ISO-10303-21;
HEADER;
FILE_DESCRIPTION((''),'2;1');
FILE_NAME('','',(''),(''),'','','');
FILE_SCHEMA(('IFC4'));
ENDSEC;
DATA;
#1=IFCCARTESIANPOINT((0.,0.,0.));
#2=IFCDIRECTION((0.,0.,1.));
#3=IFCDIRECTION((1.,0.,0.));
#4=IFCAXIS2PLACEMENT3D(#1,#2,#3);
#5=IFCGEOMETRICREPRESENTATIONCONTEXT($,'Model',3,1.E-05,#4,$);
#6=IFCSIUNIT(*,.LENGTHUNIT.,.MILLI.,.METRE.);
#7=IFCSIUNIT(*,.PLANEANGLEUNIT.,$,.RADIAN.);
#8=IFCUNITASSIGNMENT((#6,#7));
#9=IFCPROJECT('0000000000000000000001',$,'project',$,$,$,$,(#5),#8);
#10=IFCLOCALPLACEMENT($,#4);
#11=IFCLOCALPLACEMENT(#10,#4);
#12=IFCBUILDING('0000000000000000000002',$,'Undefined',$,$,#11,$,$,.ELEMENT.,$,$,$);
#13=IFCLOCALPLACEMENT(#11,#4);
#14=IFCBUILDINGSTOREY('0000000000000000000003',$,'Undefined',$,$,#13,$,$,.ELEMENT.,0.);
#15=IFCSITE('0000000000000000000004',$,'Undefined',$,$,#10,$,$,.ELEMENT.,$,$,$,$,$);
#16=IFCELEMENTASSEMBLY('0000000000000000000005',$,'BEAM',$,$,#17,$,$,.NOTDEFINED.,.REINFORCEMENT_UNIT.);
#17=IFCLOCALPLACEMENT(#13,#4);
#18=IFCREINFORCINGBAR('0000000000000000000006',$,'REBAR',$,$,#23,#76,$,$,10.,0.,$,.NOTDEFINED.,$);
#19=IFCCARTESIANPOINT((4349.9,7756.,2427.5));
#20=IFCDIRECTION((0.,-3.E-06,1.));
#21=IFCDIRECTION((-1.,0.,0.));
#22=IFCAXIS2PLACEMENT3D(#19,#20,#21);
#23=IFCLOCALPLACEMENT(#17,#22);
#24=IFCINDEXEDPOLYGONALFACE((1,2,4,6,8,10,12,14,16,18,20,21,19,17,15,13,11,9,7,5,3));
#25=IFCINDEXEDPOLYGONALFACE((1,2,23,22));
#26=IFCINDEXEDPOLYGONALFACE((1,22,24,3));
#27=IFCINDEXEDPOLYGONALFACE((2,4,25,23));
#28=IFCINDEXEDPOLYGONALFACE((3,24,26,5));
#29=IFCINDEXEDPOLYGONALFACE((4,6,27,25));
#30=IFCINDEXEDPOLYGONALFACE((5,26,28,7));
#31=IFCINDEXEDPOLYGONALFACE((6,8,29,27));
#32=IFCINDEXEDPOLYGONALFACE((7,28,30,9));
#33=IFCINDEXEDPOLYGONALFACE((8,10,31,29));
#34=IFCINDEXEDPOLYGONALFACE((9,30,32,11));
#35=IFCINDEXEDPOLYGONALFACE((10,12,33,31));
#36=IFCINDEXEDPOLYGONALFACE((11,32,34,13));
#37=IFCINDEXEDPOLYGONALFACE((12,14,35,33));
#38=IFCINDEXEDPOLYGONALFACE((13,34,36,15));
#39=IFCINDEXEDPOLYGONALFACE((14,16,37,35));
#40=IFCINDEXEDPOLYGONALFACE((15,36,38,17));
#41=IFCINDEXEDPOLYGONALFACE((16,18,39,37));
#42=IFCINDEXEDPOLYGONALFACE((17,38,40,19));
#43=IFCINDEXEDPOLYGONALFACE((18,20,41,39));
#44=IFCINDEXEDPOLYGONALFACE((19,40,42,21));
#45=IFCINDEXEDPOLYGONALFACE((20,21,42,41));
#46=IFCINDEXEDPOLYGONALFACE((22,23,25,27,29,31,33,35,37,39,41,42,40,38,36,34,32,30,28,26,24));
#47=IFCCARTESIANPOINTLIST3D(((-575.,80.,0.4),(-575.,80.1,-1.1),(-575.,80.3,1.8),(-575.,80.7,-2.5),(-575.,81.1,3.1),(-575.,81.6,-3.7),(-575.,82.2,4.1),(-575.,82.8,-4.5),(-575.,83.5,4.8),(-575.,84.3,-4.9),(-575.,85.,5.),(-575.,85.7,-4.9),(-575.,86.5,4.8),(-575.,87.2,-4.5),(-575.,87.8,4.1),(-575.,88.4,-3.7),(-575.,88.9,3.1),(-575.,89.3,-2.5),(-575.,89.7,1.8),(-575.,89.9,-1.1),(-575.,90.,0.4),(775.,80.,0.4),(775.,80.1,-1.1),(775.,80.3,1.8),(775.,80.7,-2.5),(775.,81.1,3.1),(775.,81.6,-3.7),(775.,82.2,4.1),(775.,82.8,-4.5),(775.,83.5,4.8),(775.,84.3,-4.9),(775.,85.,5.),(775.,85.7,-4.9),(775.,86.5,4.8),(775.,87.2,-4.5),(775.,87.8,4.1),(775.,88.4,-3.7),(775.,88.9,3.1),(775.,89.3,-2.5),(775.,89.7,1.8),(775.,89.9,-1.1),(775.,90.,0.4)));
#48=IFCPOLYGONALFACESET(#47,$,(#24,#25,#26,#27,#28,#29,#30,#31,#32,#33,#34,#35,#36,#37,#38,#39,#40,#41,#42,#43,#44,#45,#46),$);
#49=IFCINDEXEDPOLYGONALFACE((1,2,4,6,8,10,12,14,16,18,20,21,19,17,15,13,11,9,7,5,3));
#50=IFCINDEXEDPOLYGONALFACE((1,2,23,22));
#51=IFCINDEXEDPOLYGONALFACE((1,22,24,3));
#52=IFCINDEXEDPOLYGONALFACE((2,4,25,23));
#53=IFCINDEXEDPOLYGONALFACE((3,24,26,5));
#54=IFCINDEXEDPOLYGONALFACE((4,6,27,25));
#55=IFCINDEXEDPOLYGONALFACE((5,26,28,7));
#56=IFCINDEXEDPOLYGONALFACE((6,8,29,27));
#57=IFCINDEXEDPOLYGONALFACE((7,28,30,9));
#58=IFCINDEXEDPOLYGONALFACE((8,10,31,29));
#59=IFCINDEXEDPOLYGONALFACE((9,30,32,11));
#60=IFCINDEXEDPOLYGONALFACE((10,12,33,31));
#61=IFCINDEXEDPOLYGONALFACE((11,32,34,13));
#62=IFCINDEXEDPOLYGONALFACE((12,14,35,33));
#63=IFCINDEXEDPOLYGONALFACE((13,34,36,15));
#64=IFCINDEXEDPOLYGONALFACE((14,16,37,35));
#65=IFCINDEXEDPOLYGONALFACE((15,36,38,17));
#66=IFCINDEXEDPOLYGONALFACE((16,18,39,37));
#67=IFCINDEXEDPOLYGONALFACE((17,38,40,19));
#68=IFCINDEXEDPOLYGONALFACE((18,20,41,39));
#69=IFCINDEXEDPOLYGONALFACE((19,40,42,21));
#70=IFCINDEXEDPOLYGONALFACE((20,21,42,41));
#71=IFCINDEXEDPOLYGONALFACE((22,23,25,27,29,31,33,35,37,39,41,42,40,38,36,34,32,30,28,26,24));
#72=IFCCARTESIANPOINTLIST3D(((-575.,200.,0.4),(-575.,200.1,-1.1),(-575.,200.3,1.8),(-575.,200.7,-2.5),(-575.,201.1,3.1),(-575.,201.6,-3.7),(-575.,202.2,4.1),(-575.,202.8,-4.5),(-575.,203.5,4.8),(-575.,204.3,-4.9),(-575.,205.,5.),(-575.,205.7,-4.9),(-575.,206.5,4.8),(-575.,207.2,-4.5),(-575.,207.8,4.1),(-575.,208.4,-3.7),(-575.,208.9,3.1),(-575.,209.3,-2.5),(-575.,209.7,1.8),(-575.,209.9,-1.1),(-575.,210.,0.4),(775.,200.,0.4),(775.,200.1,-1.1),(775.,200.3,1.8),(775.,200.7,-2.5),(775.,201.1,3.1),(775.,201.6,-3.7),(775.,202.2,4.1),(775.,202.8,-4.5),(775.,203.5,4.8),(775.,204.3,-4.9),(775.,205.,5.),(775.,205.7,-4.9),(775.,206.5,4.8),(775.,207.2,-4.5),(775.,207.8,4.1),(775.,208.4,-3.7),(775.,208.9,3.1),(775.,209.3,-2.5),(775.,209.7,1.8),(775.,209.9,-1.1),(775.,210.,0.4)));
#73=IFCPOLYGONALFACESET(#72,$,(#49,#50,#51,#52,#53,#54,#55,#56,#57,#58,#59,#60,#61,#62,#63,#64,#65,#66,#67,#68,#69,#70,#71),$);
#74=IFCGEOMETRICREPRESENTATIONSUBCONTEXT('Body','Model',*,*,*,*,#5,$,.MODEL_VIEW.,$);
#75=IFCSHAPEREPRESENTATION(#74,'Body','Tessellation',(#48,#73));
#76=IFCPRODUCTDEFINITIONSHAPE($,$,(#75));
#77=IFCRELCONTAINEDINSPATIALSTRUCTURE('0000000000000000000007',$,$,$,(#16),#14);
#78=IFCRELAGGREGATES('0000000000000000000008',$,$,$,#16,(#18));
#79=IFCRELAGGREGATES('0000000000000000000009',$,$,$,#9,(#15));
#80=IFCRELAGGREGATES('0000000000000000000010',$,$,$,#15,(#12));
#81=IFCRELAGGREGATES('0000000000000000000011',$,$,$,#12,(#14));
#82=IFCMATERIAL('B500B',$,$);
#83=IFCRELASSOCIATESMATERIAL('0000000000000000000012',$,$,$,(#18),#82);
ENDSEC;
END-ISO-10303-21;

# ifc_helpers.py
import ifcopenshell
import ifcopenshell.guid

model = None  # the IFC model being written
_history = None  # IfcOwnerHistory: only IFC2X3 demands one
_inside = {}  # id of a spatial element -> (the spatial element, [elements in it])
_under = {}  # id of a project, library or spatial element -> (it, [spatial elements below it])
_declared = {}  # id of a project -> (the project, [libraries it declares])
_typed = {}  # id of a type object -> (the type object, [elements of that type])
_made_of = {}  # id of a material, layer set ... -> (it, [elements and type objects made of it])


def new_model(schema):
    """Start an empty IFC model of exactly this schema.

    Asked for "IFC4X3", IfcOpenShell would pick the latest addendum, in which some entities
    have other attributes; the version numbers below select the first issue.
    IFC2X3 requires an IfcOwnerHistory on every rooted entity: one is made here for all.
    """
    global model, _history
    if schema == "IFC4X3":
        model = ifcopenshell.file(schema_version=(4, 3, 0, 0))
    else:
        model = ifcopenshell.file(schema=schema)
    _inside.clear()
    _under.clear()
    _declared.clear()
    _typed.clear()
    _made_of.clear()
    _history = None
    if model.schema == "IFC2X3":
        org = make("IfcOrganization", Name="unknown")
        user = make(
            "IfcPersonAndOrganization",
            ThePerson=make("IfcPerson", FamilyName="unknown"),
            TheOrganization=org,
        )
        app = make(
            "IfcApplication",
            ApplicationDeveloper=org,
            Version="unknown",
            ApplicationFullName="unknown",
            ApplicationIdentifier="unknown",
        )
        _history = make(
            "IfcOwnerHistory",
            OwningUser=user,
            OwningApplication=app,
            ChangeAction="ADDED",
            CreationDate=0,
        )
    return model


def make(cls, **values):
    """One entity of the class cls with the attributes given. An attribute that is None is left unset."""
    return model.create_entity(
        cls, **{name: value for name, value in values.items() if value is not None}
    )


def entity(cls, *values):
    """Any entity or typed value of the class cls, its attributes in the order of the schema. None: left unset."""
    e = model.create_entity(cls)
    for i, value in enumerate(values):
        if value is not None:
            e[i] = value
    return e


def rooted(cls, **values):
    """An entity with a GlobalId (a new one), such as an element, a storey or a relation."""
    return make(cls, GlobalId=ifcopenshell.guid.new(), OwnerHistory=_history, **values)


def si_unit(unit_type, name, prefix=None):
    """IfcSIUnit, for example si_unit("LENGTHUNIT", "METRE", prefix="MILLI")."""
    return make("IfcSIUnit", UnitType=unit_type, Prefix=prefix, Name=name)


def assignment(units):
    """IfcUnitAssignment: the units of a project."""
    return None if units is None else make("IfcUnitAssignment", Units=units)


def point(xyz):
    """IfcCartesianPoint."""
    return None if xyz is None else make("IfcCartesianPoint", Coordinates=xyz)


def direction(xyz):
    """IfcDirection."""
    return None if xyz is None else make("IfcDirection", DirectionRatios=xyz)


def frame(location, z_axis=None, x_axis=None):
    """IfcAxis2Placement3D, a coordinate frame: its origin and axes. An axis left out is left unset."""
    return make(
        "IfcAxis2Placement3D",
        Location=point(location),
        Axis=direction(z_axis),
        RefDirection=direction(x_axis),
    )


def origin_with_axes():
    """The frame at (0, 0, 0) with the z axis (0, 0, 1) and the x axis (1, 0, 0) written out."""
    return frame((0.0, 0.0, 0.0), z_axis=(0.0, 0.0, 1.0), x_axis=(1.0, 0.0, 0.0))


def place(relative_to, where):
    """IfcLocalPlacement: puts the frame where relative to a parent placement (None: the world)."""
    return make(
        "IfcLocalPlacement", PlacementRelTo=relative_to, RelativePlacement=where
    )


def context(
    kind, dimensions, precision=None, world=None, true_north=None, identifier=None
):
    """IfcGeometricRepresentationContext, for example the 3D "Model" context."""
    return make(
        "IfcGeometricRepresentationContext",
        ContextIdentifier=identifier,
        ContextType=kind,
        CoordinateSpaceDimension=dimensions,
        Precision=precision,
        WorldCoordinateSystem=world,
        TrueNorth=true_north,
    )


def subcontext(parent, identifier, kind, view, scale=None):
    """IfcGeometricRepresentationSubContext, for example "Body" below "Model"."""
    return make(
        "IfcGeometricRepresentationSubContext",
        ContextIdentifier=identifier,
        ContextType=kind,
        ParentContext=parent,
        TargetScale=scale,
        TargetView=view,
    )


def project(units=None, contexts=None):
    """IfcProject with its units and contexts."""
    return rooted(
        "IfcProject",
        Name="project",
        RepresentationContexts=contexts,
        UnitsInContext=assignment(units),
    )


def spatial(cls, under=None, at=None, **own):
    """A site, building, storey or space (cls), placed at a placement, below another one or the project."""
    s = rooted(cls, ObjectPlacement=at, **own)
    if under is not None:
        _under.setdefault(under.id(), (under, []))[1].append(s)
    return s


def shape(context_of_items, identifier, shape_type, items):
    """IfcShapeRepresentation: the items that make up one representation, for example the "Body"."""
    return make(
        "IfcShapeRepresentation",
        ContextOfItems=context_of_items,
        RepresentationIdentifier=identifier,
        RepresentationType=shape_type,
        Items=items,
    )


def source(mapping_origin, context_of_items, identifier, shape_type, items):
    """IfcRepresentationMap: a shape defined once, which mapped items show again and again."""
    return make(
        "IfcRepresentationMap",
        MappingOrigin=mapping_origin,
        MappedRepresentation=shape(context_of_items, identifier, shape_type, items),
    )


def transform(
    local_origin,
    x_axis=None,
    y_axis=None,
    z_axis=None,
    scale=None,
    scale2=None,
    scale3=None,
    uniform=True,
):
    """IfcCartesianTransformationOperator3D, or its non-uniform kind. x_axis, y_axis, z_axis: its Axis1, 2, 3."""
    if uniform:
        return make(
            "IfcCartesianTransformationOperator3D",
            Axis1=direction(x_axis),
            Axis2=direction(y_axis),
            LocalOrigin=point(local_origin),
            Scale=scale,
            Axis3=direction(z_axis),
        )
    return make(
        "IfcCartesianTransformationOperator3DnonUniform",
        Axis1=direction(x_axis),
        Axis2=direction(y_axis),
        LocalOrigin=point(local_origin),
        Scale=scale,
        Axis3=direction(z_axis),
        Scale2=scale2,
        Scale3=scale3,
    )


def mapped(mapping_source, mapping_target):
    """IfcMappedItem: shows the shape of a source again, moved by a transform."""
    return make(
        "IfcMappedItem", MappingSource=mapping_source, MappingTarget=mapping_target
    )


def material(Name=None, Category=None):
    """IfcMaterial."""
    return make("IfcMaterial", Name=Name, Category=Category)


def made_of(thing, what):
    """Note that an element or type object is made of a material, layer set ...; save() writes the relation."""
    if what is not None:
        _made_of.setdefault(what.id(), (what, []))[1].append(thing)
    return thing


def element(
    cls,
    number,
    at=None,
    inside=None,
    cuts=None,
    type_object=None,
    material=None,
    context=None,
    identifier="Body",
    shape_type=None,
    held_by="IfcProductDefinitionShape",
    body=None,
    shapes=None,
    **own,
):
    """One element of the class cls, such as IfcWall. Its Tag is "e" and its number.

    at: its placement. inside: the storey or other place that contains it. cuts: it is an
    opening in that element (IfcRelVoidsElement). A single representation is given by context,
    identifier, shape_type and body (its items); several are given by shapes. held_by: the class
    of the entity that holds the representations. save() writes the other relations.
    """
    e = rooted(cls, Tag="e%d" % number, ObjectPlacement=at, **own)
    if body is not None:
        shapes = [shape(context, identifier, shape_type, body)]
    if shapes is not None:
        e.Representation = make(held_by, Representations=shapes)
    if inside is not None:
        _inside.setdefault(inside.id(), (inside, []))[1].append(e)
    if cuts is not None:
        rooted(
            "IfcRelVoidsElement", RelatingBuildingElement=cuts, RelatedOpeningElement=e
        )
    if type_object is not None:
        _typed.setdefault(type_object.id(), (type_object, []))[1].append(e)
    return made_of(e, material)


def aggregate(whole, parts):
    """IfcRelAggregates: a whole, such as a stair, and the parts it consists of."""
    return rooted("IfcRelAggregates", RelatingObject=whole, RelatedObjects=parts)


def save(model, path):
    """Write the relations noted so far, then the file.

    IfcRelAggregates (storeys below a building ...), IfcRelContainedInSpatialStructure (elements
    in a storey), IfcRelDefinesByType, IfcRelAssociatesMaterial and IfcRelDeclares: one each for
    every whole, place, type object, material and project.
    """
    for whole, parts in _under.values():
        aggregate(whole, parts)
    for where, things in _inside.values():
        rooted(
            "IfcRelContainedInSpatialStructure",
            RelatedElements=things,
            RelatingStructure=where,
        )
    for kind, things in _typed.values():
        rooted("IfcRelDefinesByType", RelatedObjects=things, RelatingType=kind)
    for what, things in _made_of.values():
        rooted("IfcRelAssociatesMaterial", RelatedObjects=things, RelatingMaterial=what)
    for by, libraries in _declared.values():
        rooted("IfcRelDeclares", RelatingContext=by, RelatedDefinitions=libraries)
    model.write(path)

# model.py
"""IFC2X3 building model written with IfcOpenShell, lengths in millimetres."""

from ifc_helpers import new_model, entity, si_unit, frame, origin_with_axes, place, context, subcontext, project, spatial, source, transform, mapped, material, element, aggregate, save


model = new_model("IFC2X3")

# Units and contexts
model_context = context("Model", 3, precision=1e-05, world=origin_with_axes())
body_context = subcontext(model_context, "Body", "Model", "MODEL_VIEW")
ifc_project = project(units=[si_unit("LENGTHUNIT", "METRE", prefix="MILLI"), si_unit("PLANEANGLEUNIT", "RADIAN")], contexts=[model_context])

# Site, building, storey
site_placement = place(None, origin_with_axes())
site = spatial("IfcSite", under=ifc_project, at=site_placement, Name="Undefined", CompositionType="ELEMENT")
building_placement = place(site_placement, origin_with_axes())
building = spatial("IfcBuilding", under=site, at=building_placement, Name="Undefined", CompositionType="ELEMENT")
storey_placement = place(building_placement, origin_with_axes())
storey = spatial("IfcBuildingStorey", under=building, at=storey_placement, Name="Undefined", CompositionType="ELEMENT", Elevation=0.0)

# Element assembly
assembly_1_placement = place(storey_placement, origin_with_axes())
assembly_1 = element("IfcElementAssembly", 1, at=assembly_1_placement, inside=storey, Name="BEAM", AssemblyPlace="NOTDEFINED", PredefinedType="REINFORCEMENT_UNIT")

# Shared definitions
ifc_material_1 = material(Name="B500B")

# Reinforcing bar
shared_shape_1 = source(origin_with_axes(), body_context, "Body", "AdvancedSweptSolid", [
    entity("IfcSweptDiskSolid", entity("IfcTrimmedCurve", entity("IfcLine", entity("IfcCartesianPoint", [0.0, 0.0, 0.0]), entity("IfcVector", entity("IfcDirection", [1.0, 0.0, 0.0]), 1.0)), [entity("IfcParameterValue", 0.0)], [entity("IfcParameterValue", 1349.999613)], True, "PARAMETER"), 5.0, None, 0.0, 1350.0),
])
shared_shape_2 = source(origin_with_axes(), body_context, "Body", "AdvancedSweptSolid", [
    entity("IfcSweptDiskSolid", entity("IfcTrimmedCurve", entity("IfcLine", entity("IfcCartesianPoint", [0.0, 0.0, 0.0]), entity("IfcVector", entity("IfcDirection", [1.0, 0.0, 0.0]), 1.0)), [entity("IfcParameterValue", 0.0)], [entity("IfcParameterValue", 1349.999613)], True, "PARAMETER"), 5.0, None, 0.0, 1350.0),
])
reinforcing_bar_1_placement = place(assembly_1_placement, frame((4349.9, 7756.0, 2427.5), z_axis=(0.0, -0.000003, 1.0), x_axis=(-1.0, 0.0, 0.0)))
reinforcing_bar_1 = element("IfcReinforcingBar", 2, at=reinforcing_bar_1_placement, material=ifc_material_1, Name="REBAR", BarRole="NOTDEFINED", CrossSectionArea=0.0, NominalDiameter=10.0, context=body_context, shape_type="MappedRepresentation", body=[
    mapped(shared_shape_1, transform((-575.0, 85.0, 0.0))),
    mapped(shared_shape_2, transform((-575.0, 205.0, 0.0))),
])
aggregate(assembly_1, [reinforcing_bar_1])

save(model, "model.ifc")
